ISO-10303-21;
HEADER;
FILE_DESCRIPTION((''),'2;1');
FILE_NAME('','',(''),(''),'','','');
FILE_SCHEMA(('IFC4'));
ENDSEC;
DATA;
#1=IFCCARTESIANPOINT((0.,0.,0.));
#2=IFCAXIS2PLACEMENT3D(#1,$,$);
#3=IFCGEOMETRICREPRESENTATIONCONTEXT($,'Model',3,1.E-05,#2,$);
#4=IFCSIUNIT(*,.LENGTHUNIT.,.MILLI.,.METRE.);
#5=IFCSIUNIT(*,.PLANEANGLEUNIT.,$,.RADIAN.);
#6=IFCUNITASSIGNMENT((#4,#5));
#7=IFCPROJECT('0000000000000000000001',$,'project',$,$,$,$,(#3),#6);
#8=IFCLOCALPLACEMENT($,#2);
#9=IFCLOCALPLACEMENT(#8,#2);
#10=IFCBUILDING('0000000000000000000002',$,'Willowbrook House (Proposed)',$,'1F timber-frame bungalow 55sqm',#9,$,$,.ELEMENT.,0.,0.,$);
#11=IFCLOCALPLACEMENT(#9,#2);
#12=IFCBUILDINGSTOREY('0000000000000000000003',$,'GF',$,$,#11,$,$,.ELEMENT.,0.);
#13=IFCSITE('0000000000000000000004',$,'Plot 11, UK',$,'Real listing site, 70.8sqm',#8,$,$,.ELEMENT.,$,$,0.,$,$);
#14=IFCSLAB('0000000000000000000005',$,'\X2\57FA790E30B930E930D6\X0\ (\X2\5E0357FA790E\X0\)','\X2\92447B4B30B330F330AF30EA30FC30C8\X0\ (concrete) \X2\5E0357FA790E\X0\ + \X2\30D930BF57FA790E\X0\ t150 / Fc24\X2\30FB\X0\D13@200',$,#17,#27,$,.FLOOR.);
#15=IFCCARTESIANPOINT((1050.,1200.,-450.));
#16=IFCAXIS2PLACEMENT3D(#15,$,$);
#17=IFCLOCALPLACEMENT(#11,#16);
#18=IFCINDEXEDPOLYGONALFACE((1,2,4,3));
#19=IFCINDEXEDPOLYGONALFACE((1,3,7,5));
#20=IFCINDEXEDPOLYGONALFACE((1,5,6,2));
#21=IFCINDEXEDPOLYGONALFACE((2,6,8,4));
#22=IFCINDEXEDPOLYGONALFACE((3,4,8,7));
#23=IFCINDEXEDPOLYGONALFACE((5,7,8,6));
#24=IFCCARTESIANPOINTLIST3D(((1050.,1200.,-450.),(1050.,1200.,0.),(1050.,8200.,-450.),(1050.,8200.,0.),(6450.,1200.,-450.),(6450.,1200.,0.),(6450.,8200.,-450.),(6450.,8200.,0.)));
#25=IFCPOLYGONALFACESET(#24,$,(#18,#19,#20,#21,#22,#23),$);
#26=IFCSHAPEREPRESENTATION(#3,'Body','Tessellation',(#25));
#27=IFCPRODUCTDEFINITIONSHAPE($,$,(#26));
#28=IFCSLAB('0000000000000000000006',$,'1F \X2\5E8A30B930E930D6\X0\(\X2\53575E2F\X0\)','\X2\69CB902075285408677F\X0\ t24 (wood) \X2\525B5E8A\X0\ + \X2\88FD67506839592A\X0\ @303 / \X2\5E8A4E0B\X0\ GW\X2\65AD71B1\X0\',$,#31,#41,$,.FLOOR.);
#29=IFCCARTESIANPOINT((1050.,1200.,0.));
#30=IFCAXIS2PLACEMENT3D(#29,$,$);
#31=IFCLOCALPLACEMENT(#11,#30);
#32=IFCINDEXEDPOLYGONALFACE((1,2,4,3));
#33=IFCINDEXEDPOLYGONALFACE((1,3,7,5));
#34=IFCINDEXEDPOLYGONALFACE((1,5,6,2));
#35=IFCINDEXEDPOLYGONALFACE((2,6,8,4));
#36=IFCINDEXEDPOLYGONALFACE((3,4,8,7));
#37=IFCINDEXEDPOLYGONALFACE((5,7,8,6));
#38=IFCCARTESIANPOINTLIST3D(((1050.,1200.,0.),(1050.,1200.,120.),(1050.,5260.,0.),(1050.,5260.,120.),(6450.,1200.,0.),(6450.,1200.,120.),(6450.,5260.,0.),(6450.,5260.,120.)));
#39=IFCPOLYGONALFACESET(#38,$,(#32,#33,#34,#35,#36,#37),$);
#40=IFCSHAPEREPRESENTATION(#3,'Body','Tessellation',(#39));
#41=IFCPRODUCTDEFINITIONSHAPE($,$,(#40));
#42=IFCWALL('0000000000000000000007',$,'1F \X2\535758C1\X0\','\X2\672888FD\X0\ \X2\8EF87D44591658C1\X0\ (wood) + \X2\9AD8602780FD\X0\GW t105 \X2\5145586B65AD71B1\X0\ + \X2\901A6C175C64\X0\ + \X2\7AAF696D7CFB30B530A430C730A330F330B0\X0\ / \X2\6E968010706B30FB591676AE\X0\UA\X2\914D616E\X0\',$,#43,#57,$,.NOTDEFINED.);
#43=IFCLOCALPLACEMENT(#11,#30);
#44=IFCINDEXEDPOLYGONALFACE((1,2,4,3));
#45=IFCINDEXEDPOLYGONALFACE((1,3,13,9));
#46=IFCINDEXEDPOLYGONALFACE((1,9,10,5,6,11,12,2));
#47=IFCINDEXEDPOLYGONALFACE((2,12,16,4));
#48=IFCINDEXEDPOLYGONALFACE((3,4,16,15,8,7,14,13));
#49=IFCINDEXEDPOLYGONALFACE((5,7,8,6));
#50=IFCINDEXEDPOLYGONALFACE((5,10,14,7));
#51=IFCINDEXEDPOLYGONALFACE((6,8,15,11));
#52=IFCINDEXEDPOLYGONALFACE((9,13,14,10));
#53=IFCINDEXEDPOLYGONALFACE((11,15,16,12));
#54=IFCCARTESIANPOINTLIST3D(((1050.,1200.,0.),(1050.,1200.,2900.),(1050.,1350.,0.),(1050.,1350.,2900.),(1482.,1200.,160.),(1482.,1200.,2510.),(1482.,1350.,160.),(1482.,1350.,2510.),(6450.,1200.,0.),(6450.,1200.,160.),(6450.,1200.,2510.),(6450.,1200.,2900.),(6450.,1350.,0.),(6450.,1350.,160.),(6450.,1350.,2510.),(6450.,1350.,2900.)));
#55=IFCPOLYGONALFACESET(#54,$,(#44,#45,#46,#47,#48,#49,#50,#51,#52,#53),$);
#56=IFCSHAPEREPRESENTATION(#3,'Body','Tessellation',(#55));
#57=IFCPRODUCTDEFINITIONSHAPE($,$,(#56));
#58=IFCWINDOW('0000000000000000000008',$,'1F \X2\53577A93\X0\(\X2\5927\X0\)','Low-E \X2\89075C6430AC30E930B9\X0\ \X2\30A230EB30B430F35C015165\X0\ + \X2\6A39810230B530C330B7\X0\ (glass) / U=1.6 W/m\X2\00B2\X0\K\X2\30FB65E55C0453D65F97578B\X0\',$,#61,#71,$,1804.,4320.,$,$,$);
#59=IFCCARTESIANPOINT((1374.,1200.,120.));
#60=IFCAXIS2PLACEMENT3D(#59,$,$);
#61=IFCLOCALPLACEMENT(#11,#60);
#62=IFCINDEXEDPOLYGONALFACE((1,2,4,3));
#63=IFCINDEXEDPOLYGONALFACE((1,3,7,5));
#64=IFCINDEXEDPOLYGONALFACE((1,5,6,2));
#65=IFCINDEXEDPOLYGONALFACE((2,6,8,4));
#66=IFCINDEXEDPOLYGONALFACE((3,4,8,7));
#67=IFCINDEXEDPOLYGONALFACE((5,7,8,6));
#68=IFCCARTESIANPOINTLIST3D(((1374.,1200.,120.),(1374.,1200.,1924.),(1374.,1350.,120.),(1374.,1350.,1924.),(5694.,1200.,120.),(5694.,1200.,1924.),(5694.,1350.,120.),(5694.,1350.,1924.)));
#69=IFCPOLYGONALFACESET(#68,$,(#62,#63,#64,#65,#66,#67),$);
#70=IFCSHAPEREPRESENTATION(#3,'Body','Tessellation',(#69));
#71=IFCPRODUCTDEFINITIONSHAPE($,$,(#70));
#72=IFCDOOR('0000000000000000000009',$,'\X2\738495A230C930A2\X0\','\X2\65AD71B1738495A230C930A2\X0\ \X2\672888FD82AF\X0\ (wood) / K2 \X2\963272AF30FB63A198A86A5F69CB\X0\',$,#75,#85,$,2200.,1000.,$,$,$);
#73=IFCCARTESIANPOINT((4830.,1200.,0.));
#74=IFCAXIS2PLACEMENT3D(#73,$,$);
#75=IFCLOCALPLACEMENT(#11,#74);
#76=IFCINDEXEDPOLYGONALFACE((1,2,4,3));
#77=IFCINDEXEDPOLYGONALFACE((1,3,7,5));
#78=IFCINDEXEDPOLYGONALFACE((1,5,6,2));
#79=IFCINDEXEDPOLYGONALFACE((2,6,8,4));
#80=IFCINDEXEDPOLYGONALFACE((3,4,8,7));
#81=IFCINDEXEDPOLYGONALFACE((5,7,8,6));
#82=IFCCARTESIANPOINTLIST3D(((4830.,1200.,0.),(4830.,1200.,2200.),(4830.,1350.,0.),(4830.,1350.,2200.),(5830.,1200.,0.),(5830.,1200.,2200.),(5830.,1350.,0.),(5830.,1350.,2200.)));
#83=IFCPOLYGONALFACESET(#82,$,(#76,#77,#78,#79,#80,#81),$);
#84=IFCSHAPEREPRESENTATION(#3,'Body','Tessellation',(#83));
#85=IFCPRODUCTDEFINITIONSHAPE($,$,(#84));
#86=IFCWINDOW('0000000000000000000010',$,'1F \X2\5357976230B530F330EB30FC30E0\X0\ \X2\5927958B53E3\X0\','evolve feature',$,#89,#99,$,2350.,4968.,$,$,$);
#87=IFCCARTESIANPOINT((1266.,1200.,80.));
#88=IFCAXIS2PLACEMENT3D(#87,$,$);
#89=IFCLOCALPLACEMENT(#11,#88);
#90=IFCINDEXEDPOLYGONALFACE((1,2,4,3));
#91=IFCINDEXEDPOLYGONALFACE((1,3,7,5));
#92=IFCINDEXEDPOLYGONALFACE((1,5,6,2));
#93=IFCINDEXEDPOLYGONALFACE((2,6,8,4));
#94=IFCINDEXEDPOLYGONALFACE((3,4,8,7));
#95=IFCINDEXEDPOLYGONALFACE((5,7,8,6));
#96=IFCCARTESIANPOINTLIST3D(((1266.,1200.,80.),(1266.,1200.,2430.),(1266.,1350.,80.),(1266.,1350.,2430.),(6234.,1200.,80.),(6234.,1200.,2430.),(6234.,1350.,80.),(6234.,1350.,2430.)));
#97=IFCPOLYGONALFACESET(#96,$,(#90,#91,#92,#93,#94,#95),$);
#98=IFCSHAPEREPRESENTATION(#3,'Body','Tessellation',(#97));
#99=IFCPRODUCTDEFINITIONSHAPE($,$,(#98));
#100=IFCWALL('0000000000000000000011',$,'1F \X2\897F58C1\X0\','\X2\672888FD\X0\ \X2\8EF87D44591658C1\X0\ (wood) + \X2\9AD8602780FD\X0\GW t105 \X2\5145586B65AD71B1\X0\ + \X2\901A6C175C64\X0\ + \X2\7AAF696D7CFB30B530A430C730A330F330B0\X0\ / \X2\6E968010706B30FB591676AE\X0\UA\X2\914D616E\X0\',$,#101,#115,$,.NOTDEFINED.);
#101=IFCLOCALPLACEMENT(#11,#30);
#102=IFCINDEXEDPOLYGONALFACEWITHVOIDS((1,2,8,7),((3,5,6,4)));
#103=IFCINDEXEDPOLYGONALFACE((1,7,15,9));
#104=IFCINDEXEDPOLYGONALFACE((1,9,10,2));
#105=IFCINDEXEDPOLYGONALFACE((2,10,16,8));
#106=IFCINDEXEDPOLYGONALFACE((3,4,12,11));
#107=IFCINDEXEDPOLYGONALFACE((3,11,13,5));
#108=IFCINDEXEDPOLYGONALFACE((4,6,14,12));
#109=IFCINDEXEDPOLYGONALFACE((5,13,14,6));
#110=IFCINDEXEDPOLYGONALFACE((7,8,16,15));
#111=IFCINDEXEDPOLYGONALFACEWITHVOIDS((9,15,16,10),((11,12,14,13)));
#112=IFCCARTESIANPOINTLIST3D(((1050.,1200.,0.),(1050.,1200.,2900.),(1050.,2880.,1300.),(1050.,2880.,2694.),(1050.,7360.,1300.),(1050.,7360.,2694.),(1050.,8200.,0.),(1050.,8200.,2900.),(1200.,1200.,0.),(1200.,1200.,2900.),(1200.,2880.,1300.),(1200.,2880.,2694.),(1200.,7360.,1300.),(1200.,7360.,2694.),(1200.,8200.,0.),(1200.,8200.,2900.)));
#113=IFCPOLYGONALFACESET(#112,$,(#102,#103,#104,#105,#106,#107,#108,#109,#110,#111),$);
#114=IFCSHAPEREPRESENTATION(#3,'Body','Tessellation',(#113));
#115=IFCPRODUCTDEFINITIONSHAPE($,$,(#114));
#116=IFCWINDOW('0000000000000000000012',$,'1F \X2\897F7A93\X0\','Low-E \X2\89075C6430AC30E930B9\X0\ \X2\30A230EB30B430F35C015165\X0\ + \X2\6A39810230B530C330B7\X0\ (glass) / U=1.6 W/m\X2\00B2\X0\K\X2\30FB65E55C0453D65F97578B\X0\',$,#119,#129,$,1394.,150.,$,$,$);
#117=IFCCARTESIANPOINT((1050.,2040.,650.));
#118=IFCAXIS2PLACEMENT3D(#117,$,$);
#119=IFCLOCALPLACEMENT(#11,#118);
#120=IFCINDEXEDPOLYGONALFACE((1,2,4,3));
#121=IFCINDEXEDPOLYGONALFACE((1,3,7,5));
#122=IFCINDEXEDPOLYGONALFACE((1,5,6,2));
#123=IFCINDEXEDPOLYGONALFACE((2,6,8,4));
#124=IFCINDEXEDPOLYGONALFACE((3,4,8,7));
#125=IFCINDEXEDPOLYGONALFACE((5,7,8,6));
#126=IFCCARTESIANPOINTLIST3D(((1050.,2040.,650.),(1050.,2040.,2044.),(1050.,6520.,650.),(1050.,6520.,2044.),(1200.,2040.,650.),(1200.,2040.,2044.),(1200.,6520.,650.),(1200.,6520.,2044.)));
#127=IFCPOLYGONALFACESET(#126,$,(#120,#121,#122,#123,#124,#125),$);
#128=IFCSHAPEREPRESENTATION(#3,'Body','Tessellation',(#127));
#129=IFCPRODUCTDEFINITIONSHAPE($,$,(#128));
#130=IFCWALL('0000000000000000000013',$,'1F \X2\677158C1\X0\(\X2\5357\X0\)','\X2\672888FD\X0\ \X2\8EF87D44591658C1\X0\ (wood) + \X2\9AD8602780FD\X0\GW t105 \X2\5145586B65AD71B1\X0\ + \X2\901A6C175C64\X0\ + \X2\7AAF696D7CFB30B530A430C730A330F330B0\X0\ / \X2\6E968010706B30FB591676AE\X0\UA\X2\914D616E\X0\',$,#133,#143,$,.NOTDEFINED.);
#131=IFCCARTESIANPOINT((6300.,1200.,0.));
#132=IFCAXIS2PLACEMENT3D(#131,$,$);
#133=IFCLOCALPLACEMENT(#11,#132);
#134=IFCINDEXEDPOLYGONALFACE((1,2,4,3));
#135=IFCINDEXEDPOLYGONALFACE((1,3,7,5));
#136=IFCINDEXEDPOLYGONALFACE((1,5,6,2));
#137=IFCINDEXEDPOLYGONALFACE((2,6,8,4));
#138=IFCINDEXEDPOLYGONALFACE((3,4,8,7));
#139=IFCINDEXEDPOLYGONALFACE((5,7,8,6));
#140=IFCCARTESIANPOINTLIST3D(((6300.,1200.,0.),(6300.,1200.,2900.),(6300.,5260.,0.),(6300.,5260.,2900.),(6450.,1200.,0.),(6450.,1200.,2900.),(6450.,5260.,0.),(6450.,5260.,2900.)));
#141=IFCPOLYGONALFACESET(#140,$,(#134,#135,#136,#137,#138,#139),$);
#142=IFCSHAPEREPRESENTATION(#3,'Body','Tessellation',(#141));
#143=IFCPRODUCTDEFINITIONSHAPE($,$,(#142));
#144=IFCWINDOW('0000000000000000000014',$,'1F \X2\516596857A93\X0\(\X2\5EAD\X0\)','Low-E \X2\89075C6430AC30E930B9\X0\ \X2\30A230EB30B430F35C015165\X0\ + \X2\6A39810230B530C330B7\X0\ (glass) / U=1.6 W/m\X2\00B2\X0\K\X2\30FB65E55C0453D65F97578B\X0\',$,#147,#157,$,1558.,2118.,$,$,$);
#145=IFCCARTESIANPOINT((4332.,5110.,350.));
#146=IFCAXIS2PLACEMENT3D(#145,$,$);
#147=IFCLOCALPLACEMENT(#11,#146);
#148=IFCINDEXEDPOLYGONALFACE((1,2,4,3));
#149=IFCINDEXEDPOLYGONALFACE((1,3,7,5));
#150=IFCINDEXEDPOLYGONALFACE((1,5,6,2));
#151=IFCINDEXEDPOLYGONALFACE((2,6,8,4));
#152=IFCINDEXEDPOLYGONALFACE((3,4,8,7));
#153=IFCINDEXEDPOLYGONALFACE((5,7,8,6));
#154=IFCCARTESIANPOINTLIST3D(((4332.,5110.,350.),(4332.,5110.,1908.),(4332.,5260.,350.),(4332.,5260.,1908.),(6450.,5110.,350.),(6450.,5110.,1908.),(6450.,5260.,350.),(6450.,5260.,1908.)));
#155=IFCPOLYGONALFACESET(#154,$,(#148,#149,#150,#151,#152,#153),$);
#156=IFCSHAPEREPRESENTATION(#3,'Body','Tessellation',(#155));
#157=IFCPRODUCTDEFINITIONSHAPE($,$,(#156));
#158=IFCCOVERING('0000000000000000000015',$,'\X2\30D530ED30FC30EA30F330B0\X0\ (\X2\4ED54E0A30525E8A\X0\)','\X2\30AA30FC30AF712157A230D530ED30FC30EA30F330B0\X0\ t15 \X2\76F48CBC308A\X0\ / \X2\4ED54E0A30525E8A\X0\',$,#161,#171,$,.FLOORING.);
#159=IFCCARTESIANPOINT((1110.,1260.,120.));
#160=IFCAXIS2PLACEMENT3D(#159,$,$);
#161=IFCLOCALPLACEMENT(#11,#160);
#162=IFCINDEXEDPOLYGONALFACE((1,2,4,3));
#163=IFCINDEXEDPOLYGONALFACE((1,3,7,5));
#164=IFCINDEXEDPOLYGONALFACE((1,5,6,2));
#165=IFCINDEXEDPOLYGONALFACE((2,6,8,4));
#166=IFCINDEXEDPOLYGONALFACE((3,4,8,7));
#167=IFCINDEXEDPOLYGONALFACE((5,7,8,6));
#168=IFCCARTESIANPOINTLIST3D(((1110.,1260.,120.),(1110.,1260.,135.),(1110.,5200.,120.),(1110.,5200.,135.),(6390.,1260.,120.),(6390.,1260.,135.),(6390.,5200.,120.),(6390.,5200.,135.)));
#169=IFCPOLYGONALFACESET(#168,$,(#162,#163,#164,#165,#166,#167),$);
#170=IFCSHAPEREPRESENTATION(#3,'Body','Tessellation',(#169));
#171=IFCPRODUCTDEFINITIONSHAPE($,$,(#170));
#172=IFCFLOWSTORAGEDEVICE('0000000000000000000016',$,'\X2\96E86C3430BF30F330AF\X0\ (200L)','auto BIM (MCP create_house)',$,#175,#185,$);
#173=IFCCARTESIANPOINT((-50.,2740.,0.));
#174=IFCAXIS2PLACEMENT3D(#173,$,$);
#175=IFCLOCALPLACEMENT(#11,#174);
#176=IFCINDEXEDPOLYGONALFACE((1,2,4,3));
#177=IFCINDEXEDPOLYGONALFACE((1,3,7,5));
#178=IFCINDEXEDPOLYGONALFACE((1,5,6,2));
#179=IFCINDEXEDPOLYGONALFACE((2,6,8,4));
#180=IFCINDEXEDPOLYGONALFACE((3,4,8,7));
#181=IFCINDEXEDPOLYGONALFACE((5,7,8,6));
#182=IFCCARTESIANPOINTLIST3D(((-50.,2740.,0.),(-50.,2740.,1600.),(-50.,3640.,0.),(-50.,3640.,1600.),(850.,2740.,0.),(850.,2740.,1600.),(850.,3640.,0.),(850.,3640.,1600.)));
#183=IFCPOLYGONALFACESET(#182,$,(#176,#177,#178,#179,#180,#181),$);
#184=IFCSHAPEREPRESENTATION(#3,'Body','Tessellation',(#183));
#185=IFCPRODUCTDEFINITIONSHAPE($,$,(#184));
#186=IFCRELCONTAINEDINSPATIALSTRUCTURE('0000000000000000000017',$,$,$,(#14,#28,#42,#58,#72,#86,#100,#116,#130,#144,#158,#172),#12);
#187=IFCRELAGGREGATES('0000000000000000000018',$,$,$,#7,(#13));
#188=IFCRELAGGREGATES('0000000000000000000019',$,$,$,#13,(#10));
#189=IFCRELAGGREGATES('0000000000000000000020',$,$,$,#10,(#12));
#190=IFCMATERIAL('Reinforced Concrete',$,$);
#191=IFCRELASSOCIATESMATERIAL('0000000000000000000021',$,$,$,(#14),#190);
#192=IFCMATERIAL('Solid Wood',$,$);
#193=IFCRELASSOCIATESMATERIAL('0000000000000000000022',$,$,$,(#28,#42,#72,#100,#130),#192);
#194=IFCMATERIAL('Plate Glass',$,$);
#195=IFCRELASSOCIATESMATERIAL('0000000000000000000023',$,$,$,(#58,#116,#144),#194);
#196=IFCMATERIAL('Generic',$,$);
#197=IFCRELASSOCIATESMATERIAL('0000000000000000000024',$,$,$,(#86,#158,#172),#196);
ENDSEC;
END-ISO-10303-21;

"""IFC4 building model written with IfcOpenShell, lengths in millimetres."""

from ifc_helpers import new_model, si_unit, frame, frame_2d, origin, place, context, project, spatial, rectangle, extrude, material, element, fill, save


model = new_model("IFC4")

# Units and contexts
model_context = context("Model", 3, precision=1e-05, world=origin())
ifc_project = project(units=[si_unit("LENGTHUNIT", "METRE", prefix="MILLI"), si_unit("PLANEANGLEUNIT", "RADIAN")], contexts=[model_context])

# Site, building, storey
site_placement = place(None, origin())
site = spatial("IfcSite", under=ifc_project, at=site_placement, Name="Plot 11, UK", ObjectType="Real listing site, 70.8sqm", CompositionType="ELEMENT", RefElevation=0.0)
building_placement = place(site_placement, origin())
building = spatial("IfcBuilding", under=site, at=building_placement, Name="Willowbrook House (Proposed)", ObjectType="1F timber-frame bungalow 55sqm", CompositionType="ELEMENT", ElevationOfRefHeight=0.0, ElevationOfTerrain=0.0)
storey_placement = place(building_placement, origin())
storey = spatial("IfcBuildingStorey", under=building, at=storey_placement, Name="GF", CompositionType="ELEMENT", Elevation=0.0)

# Slabs
ifc_material_1 = material(Name="Reinforced Concrete")
slab_1_placement = place(storey_placement, frame((1050.0, 1200.0, -450.0)))
element("IfcSlab", 1, at=slab_1_placement, inside=storey, material=ifc_material_1, Name="基礎スラブ (布基礎)", Description="鉄筋コンクリート (concrete) 布基礎 + ベタ基礎 t150 / Fc24・D13@200", PredefinedType="FLOOR", context=model_context, shape_type="SweptSolid", body=[
    extrude(rectangle(XDim=5400.0, YDim=7000.0, at=frame_2d((2700.0, 3500.0))), frame((1050.0, 1200.0, -450.0)), (0.0, 0.0, 1.0), 450.0),
])
ifc_material_2 = material(Name="Solid Wood")
slab_2_placement = place(storey_placement, frame((1050.0, 1200.0, 0.0)))
element("IfcSlab", 2, at=slab_2_placement, inside=storey, material=ifc_material_2, Name="1F 床スラブ(南帯)", Description="構造用合板 t24 (wood) 剛床 + 製材根太 @303 / 床下 GW断熱", PredefinedType="FLOOR", context=model_context, shape_type="SweptSolid", body=[
    extrude(rectangle(XDim=5400.0, YDim=4060.0, at=frame_2d((2700.0, 2030.0))), frame((1050.0, 1200.0, 0.0)), (0.0, 0.0, 1.0), 120.0),
])

# Wall, openings, windows, door
wall_1_placement = place(storey_placement, frame((1050.0, 1200.0, 0.0)))
wall_1 = element("IfcWall", 3, at=wall_1_placement, inside=storey, material=ifc_material_2, Name="1F 南壁", Description="木製 軸組外壁 (wood) + 高性能GW t105 充填断熱 + 通気層 + 窯業系サイディング / 準耐火・外皮UA配慮", PredefinedType="NOTDEFINED", context=model_context, shape_type="SweptSolid", body=[
    extrude(rectangle(XDim=5400.0, YDim=150.0, at=frame_2d((2700.0, 75.0))), frame((1050.0, 1200.0, 0.0)), (0.0, 0.0, 1.0), 2900.0),
])
opening_1_placement = place(storey_placement, frame((1374.0, 1200.0, 120.0)))
opening_1 = element("IfcOpeningElement", 4, at=opening_1_placement, cuts=wall_1, PredefinedType="NOTDEFINED", context=model_context, shape_type="SweptSolid", body=[
    extrude(rectangle(XDim=4320.0, YDim=150.0, at=frame_2d((2160.0, 75.0))), frame((1374.0, 1200.0, 120.0)), (0.0, 0.0, 1.0), 1804.0),
])
opening_2_placement = place(storey_placement, frame((4830.0, 1200.0, 0.0)))
opening_2 = element("IfcOpeningElement", 5, at=opening_2_placement, cuts=wall_1, PredefinedType="NOTDEFINED", context=model_context, shape_type="SweptSolid", body=[
    extrude(rectangle(XDim=1000.0, YDim=150.0, at=frame_2d((500.0, 75.0))), frame((4830.0, 1200.0, 0.0)), (0.0, 0.0, 1.0), 2200.0),
])
opening_3_placement = place(storey_placement, frame((1266.0, 1200.0, 80.0)))
opening_3 = element("IfcOpeningElement", 6, at=opening_3_placement, cuts=wall_1, PredefinedType="NOTDEFINED", context=model_context, shape_type="SweptSolid", body=[
    extrude(rectangle(XDim=4968.0, YDim=150.0, at=frame_2d((2484.0, 75.0))), frame((1266.0, 1200.0, 80.0)), (0.0, 0.0, 1.0), 2350.0),
])
ifc_material_3 = material(Name="Plate Glass")
window_1_placement = place(storey_placement, frame((1374.0, 1200.0, 120.0)))
window_1 = element("IfcWindow", 7, at=window_1_placement, inside=storey, material=ifc_material_3, Name="1F 南窓(大)", Description="Low-E 複層ガラス アルゴン封入 + 樹脂サッシ (glass) / U=1.6 W/m²K・日射取得型", OverallHeight=1804.0, OverallWidth=4320.0, context=model_context, shape_type="SweptSolid", body=[
    extrude(rectangle(XDim=4320.0, YDim=150.0, at=frame_2d((2160.0, 75.0))), frame((1374.0, 1200.0, 120.0)), (0.0, 0.0, 1.0), 1804.0),
])
fill(opening_1, window_1)
door_1_placement = place(storey_placement, frame((4830.0, 1200.0, 0.0)))
door_1 = element("IfcDoor", 8, at=door_1_placement, inside=storey, material=ifc_material_2, Name="玄関ドア", Description="断熱玄関ドア 木製芯 (wood) / K2 防犯・採風機構", OverallHeight=2200.0, OverallWidth=1000.0, context=model_context, shape_type="SweptSolid", body=[
    extrude(rectangle(XDim=1000.0, YDim=150.0, at=frame_2d((500.0, 75.0))), frame((4830.0, 1200.0, 0.0)), (0.0, 0.0, 1.0), 2200.0),
])
fill(opening_2, door_1)
ifc_material_4 = material(Name="Generic")
window_2_placement = place(storey_placement, frame((1266.0, 1200.0, 80.0)))
window_2 = element("IfcWindow", 9, at=window_2_placement, inside=storey, material=ifc_material_4, Name="1F 南面サンルーム 大開口", Description="evolve feature", OverallHeight=2350.0, OverallWidth=4968.0, context=model_context, shape_type="SweptSolid", body=[
    extrude(rectangle(XDim=4968.0, YDim=150.0, at=frame_2d((2484.0, 75.0))), frame((1266.0, 1200.0, 80.0)), (0.0, 0.0, 1.0), 2350.0),
])
fill(opening_3, window_2)

# Walls, openings, windows
wall_2_placement = place(storey_placement, frame((1050.0, 1200.0, 0.0)))
wall_2 = element("IfcWall", 10, at=wall_2_placement, inside=storey, material=ifc_material_2, Name="1F 西壁", Description="木製 軸組外壁 (wood) + 高性能GW t105 充填断熱 + 通気層 + 窯業系サイディング / 準耐火・外皮UA配慮", PredefinedType="NOTDEFINED", context=model_context, shape_type="SweptSolid", body=[
    extrude(rectangle(XDim=150.0, YDim=7000.0, at=frame_2d((75.0, 3500.0))), frame((1050.0, 1200.0, 0.0)), (0.0, 0.0, 1.0), 2900.0),
])
opening_4_placement = place(storey_placement, frame((1050.0, 2040.0, 650.0)))
opening_4 = element("IfcOpeningElement", 11, at=opening_4_placement, cuts=wall_2, PredefinedType="NOTDEFINED", context=model_context, shape_type="SweptSolid", body=[
    extrude(rectangle(XDim=150.0, YDim=4480.0, at=frame_2d((75.0, 2240.0))), frame((1050.0, 2040.0, 650.0)), (0.0, 0.0, 1.0), 1394.0),
])
window_3_placement = place(storey_placement, frame((1050.0, 2040.0, 650.0)))
window_3 = element("IfcWindow", 12, at=window_3_placement, inside=storey, material=ifc_material_3, Name="1F 西窓", Description="Low-E 複層ガラス アルゴン封入 + 樹脂サッシ (glass) / U=1.6 W/m²K・日射取得型", OverallHeight=1394.0, OverallWidth=150.0, context=model_context, shape_type="SweptSolid", body=[
    extrude(rectangle(XDim=150.0, YDim=4480.0, at=frame_2d((75.0, 2240.0))), frame((1050.0, 2040.0, 650.0)), (0.0, 0.0, 1.0), 1394.0),
])
fill(opening_4, window_3)
wall_3_placement = place(storey_placement, frame((6300.0, 1200.0, 0.0)))
wall_3 = element("IfcWall", 13, at=wall_3_placement, inside=storey, material=ifc_material_2, Name="1F 東壁(南)", Description="木製 軸組外壁 (wood) + 高性能GW t105 充填断熱 + 通気層 + 窯業系サイディング / 準耐火・外皮UA配慮", PredefinedType="NOTDEFINED", context=model_context, shape_type="SweptSolid", body=[
    extrude(rectangle(XDim=150.0, YDim=4060.0, at=frame_2d((75.0, 2030.0))), frame((6300.0, 1200.0, 0.0)), (0.0, 0.0, 1.0), 2900.0),
])
opening_5_placement = place(storey_placement, frame((4332.0, 5110.0, 350.0)))
opening_5 = element("IfcOpeningElement", 14, at=opening_5_placement, cuts=wall_3, PredefinedType="NOTDEFINED", context=model_context, shape_type="SweptSolid", body=[
    extrude(rectangle(XDim=2118.0, YDim=150.0, at=frame_2d((1059.0, 75.0))), frame((4332.0, 5110.0, 350.0)), (0.0, 0.0, 1.0), 1558.0),
])
window_4_placement = place(storey_placement, frame((4332.0, 5110.0, 350.0)))
window_4 = element("IfcWindow", 15, at=window_4_placement, inside=storey, material=ifc_material_3, Name="1F 入隅窓(庭)", Description="Low-E 複層ガラス アルゴン封入 + 樹脂サッシ (glass) / U=1.6 W/m²K・日射取得型", OverallHeight=1558.0, OverallWidth=2118.0, context=model_context, shape_type="SweptSolid", body=[
    extrude(rectangle(XDim=2118.0, YDim=150.0, at=frame_2d((1059.0, 75.0))), frame((4332.0, 5110.0, 350.0)), (0.0, 0.0, 1.0), 1558.0),
])
fill(opening_5, window_4)

# Covering
covering_placement = place(storey_placement, frame((1110.0, 1260.0, 120.0)))
element("IfcCovering", 16, at=covering_placement, inside=storey, material=ifc_material_4, Name="フローリング (仕上げ床)", Description="オーク無垢フローリング t15 直貼り / 仕上げ床", PredefinedType="FLOORING", context=model_context, shape_type="SweptSolid", body=[
    extrude(rectangle(XDim=5280.0, YDim=3940.0, at=frame_2d((2640.0, 1970.0))), frame((1110.0, 1260.0, 120.0)), (0.0, 0.0, 1.0), 15.0),
])

# Flow storage device
flow_storage_device_placement = place(storey_placement, frame((-50.0, 2740.0, 0.0)))
element("IfcFlowStorageDevice", 17, at=flow_storage_device_placement, inside=storey, material=ifc_material_4, Name="雨水タンク (200L)", Description="auto BIM (MCP create_house)", context=model_context, shape_type="SweptSolid", body=[
    extrude(rectangle(XDim=900.0, YDim=900.0, at=frame_2d((450.0, 450.0))), frame((-50.0, 2740.0, 0.0)), (0.0, 0.0, 1.0), 1600.0),
])

save(model, "model.ifc")
